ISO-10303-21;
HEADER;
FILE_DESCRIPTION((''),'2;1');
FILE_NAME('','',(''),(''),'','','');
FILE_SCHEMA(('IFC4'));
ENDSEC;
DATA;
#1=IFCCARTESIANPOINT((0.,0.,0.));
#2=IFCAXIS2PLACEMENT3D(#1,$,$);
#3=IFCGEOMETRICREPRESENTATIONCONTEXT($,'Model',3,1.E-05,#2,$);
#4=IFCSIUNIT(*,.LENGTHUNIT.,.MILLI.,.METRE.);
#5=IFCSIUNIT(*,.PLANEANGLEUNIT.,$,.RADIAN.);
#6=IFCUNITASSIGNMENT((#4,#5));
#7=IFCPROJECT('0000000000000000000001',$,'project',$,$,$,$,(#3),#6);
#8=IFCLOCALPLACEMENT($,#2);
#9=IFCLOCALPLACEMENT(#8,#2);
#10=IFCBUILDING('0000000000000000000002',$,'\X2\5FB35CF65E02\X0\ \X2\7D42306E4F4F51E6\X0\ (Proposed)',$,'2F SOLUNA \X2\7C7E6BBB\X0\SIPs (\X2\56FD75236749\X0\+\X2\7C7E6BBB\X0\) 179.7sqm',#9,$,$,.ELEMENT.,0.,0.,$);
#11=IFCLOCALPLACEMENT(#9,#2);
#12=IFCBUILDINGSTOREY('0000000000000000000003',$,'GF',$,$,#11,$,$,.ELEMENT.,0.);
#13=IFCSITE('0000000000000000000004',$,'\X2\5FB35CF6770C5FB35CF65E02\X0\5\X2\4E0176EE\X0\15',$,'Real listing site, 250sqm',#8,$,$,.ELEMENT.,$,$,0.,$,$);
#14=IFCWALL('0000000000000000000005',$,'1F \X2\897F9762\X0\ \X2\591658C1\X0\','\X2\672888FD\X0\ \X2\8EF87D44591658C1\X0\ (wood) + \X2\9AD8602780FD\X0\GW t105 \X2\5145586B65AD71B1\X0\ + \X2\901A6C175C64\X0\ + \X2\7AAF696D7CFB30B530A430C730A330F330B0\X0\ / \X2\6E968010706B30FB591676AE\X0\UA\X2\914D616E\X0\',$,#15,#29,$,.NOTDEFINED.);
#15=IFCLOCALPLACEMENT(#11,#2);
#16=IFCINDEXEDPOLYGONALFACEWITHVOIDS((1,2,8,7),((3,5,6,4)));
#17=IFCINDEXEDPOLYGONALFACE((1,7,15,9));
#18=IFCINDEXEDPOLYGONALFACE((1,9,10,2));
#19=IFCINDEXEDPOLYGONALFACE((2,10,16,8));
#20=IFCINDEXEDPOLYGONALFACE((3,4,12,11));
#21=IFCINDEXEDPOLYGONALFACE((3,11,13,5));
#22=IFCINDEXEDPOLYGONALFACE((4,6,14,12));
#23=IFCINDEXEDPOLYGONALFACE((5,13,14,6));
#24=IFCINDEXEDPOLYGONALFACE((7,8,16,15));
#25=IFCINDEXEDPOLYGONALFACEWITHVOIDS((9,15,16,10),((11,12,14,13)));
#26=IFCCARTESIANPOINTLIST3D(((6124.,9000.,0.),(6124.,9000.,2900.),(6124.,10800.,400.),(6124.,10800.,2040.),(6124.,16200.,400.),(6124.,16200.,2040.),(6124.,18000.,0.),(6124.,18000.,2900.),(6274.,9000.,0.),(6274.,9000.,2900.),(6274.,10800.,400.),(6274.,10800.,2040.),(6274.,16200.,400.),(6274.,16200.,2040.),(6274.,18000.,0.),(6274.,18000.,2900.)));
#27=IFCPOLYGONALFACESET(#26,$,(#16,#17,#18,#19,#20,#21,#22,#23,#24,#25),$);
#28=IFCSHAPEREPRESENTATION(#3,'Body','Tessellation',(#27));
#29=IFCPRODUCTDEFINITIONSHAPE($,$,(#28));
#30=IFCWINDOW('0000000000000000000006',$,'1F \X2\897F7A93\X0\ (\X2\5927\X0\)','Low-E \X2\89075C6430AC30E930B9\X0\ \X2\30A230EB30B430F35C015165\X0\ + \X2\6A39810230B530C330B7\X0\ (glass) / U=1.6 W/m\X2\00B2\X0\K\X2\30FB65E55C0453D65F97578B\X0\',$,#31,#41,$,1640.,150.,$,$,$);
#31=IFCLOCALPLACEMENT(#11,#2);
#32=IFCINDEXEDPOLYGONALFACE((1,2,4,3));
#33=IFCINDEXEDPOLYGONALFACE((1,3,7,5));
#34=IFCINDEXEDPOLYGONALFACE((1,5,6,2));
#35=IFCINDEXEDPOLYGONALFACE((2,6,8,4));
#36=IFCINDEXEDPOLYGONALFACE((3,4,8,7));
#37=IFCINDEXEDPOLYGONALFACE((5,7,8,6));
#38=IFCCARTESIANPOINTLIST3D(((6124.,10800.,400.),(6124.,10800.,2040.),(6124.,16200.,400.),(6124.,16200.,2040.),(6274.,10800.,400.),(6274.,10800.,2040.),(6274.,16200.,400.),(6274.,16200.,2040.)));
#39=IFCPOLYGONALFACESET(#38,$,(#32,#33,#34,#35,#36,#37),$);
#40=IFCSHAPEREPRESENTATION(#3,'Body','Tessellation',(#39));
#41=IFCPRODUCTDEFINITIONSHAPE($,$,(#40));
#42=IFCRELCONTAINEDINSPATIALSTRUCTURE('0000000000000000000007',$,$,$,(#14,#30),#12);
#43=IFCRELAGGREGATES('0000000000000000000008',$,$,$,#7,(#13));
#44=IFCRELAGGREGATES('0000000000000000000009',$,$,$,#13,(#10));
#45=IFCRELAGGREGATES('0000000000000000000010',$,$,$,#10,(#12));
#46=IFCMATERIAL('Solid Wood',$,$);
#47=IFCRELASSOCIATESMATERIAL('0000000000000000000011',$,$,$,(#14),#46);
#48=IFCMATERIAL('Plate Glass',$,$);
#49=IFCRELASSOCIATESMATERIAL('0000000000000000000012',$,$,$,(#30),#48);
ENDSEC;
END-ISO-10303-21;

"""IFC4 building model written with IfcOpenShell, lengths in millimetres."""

from ifc_helpers import new_model, si_unit, frame, frame_2d, origin, place, context, project, spatial, rectangle, extrude, material, element, fill, save


model = new_model("IFC4")

# Units and contexts
model_context = context("Model", 3, precision=1e-05, world=origin())
ifc_project = project(units=[si_unit("LENGTHUNIT", "METRE", prefix="MILLI"), si_unit("PLANEANGLEUNIT", "RADIAN")], contexts=[model_context])

# Site, building, storey
site_placement = place(None, origin())
site = spatial("IfcSite", under=ifc_project, at=site_placement, Name="徳島県徳島市5丁目15", ObjectType="Real listing site, 250sqm", CompositionType="ELEMENT", RefElevation=0.0)
building_placement = place(site_placement, origin())
building = spatial("IfcBuilding", under=site, at=building_placement, Name="徳島市 終の住処 (Proposed)", ObjectType="2F SOLUNA 籾殻SIPs (国産杉+籾殻) 179.7sqm", CompositionType="ELEMENT", ElevationOfRefHeight=0.0, ElevationOfTerrain=0.0)
storey_placement = place(building_placement, origin())
storey = spatial("IfcBuildingStorey", under=building, at=storey_placement, Name="GF", CompositionType="ELEMENT", Elevation=0.0)

# Shared definitions
ifc_material_1 = material(Name="Solid Wood")

# Shared definitions
ifc_material_2 = material(Name="Plate Glass")

# Wall, opening, window
wall_1_placement = place(storey_placement, frame((3062.0, 4500.0, 0.0)))
wall_1 = element("IfcWall", 1, at=wall_1_placement, inside=storey, material=ifc_material_1, Name="1F 西面 外壁", Description="木製 軸組外壁 (wood) + 高性能GW t105 充填断熱 + 通気層 + 窯業系サイディング / 準耐火・外皮UA配慮", PredefinedType="NOTDEFINED", context=model_context, shape_type="SweptSolid", body=[
    extrude(rectangle(XDim=150.0, YDim=9000.0, at=frame_2d((75.0, 4500.0))), frame((3062.0, 4500.0, 0.0)), (0.0, 0.0, 1.0), 2900.0),
])
opening_1_placement = place(storey_placement, frame((3062.0, 5400.0, 200.0)))
opening_1 = element("IfcOpeningElement", 2, at=opening_1_placement, cuts=wall_1, PredefinedType="NOTDEFINED", context=model_context, shape_type="SweptSolid", body=[
    extrude(rectangle(XDim=150.0, YDim=5400.0, at=frame_2d((75.0, 2700.0))), frame((3062.0, 5400.0, 200.0)), (0.0, 0.0, 1.0), 1640.0),
])
window_1_placement = place(storey_placement, frame((3062.0, 5400.0, 200.0)))
window_1 = element("IfcWindow", 3, at=window_1_placement, inside=storey, material=ifc_material_2, Name="1F 西窓 (大)", Description="Low-E 複層ガラス アルゴン封入 + 樹脂サッシ (glass) / U=1.6 W/m²K・日射取得型", OverallHeight=1640.0, OverallWidth=150.0, context=model_context, shape_type="SweptSolid", body=[
    extrude(rectangle(XDim=150.0, YDim=5400.0, at=frame_2d((75.0, 2700.0))), frame((3062.0, 5400.0, 200.0)), (0.0, 0.0, 1.0), 1640.0),
])
fill(opening_1, window_1)

save(model, "model.ifc")
